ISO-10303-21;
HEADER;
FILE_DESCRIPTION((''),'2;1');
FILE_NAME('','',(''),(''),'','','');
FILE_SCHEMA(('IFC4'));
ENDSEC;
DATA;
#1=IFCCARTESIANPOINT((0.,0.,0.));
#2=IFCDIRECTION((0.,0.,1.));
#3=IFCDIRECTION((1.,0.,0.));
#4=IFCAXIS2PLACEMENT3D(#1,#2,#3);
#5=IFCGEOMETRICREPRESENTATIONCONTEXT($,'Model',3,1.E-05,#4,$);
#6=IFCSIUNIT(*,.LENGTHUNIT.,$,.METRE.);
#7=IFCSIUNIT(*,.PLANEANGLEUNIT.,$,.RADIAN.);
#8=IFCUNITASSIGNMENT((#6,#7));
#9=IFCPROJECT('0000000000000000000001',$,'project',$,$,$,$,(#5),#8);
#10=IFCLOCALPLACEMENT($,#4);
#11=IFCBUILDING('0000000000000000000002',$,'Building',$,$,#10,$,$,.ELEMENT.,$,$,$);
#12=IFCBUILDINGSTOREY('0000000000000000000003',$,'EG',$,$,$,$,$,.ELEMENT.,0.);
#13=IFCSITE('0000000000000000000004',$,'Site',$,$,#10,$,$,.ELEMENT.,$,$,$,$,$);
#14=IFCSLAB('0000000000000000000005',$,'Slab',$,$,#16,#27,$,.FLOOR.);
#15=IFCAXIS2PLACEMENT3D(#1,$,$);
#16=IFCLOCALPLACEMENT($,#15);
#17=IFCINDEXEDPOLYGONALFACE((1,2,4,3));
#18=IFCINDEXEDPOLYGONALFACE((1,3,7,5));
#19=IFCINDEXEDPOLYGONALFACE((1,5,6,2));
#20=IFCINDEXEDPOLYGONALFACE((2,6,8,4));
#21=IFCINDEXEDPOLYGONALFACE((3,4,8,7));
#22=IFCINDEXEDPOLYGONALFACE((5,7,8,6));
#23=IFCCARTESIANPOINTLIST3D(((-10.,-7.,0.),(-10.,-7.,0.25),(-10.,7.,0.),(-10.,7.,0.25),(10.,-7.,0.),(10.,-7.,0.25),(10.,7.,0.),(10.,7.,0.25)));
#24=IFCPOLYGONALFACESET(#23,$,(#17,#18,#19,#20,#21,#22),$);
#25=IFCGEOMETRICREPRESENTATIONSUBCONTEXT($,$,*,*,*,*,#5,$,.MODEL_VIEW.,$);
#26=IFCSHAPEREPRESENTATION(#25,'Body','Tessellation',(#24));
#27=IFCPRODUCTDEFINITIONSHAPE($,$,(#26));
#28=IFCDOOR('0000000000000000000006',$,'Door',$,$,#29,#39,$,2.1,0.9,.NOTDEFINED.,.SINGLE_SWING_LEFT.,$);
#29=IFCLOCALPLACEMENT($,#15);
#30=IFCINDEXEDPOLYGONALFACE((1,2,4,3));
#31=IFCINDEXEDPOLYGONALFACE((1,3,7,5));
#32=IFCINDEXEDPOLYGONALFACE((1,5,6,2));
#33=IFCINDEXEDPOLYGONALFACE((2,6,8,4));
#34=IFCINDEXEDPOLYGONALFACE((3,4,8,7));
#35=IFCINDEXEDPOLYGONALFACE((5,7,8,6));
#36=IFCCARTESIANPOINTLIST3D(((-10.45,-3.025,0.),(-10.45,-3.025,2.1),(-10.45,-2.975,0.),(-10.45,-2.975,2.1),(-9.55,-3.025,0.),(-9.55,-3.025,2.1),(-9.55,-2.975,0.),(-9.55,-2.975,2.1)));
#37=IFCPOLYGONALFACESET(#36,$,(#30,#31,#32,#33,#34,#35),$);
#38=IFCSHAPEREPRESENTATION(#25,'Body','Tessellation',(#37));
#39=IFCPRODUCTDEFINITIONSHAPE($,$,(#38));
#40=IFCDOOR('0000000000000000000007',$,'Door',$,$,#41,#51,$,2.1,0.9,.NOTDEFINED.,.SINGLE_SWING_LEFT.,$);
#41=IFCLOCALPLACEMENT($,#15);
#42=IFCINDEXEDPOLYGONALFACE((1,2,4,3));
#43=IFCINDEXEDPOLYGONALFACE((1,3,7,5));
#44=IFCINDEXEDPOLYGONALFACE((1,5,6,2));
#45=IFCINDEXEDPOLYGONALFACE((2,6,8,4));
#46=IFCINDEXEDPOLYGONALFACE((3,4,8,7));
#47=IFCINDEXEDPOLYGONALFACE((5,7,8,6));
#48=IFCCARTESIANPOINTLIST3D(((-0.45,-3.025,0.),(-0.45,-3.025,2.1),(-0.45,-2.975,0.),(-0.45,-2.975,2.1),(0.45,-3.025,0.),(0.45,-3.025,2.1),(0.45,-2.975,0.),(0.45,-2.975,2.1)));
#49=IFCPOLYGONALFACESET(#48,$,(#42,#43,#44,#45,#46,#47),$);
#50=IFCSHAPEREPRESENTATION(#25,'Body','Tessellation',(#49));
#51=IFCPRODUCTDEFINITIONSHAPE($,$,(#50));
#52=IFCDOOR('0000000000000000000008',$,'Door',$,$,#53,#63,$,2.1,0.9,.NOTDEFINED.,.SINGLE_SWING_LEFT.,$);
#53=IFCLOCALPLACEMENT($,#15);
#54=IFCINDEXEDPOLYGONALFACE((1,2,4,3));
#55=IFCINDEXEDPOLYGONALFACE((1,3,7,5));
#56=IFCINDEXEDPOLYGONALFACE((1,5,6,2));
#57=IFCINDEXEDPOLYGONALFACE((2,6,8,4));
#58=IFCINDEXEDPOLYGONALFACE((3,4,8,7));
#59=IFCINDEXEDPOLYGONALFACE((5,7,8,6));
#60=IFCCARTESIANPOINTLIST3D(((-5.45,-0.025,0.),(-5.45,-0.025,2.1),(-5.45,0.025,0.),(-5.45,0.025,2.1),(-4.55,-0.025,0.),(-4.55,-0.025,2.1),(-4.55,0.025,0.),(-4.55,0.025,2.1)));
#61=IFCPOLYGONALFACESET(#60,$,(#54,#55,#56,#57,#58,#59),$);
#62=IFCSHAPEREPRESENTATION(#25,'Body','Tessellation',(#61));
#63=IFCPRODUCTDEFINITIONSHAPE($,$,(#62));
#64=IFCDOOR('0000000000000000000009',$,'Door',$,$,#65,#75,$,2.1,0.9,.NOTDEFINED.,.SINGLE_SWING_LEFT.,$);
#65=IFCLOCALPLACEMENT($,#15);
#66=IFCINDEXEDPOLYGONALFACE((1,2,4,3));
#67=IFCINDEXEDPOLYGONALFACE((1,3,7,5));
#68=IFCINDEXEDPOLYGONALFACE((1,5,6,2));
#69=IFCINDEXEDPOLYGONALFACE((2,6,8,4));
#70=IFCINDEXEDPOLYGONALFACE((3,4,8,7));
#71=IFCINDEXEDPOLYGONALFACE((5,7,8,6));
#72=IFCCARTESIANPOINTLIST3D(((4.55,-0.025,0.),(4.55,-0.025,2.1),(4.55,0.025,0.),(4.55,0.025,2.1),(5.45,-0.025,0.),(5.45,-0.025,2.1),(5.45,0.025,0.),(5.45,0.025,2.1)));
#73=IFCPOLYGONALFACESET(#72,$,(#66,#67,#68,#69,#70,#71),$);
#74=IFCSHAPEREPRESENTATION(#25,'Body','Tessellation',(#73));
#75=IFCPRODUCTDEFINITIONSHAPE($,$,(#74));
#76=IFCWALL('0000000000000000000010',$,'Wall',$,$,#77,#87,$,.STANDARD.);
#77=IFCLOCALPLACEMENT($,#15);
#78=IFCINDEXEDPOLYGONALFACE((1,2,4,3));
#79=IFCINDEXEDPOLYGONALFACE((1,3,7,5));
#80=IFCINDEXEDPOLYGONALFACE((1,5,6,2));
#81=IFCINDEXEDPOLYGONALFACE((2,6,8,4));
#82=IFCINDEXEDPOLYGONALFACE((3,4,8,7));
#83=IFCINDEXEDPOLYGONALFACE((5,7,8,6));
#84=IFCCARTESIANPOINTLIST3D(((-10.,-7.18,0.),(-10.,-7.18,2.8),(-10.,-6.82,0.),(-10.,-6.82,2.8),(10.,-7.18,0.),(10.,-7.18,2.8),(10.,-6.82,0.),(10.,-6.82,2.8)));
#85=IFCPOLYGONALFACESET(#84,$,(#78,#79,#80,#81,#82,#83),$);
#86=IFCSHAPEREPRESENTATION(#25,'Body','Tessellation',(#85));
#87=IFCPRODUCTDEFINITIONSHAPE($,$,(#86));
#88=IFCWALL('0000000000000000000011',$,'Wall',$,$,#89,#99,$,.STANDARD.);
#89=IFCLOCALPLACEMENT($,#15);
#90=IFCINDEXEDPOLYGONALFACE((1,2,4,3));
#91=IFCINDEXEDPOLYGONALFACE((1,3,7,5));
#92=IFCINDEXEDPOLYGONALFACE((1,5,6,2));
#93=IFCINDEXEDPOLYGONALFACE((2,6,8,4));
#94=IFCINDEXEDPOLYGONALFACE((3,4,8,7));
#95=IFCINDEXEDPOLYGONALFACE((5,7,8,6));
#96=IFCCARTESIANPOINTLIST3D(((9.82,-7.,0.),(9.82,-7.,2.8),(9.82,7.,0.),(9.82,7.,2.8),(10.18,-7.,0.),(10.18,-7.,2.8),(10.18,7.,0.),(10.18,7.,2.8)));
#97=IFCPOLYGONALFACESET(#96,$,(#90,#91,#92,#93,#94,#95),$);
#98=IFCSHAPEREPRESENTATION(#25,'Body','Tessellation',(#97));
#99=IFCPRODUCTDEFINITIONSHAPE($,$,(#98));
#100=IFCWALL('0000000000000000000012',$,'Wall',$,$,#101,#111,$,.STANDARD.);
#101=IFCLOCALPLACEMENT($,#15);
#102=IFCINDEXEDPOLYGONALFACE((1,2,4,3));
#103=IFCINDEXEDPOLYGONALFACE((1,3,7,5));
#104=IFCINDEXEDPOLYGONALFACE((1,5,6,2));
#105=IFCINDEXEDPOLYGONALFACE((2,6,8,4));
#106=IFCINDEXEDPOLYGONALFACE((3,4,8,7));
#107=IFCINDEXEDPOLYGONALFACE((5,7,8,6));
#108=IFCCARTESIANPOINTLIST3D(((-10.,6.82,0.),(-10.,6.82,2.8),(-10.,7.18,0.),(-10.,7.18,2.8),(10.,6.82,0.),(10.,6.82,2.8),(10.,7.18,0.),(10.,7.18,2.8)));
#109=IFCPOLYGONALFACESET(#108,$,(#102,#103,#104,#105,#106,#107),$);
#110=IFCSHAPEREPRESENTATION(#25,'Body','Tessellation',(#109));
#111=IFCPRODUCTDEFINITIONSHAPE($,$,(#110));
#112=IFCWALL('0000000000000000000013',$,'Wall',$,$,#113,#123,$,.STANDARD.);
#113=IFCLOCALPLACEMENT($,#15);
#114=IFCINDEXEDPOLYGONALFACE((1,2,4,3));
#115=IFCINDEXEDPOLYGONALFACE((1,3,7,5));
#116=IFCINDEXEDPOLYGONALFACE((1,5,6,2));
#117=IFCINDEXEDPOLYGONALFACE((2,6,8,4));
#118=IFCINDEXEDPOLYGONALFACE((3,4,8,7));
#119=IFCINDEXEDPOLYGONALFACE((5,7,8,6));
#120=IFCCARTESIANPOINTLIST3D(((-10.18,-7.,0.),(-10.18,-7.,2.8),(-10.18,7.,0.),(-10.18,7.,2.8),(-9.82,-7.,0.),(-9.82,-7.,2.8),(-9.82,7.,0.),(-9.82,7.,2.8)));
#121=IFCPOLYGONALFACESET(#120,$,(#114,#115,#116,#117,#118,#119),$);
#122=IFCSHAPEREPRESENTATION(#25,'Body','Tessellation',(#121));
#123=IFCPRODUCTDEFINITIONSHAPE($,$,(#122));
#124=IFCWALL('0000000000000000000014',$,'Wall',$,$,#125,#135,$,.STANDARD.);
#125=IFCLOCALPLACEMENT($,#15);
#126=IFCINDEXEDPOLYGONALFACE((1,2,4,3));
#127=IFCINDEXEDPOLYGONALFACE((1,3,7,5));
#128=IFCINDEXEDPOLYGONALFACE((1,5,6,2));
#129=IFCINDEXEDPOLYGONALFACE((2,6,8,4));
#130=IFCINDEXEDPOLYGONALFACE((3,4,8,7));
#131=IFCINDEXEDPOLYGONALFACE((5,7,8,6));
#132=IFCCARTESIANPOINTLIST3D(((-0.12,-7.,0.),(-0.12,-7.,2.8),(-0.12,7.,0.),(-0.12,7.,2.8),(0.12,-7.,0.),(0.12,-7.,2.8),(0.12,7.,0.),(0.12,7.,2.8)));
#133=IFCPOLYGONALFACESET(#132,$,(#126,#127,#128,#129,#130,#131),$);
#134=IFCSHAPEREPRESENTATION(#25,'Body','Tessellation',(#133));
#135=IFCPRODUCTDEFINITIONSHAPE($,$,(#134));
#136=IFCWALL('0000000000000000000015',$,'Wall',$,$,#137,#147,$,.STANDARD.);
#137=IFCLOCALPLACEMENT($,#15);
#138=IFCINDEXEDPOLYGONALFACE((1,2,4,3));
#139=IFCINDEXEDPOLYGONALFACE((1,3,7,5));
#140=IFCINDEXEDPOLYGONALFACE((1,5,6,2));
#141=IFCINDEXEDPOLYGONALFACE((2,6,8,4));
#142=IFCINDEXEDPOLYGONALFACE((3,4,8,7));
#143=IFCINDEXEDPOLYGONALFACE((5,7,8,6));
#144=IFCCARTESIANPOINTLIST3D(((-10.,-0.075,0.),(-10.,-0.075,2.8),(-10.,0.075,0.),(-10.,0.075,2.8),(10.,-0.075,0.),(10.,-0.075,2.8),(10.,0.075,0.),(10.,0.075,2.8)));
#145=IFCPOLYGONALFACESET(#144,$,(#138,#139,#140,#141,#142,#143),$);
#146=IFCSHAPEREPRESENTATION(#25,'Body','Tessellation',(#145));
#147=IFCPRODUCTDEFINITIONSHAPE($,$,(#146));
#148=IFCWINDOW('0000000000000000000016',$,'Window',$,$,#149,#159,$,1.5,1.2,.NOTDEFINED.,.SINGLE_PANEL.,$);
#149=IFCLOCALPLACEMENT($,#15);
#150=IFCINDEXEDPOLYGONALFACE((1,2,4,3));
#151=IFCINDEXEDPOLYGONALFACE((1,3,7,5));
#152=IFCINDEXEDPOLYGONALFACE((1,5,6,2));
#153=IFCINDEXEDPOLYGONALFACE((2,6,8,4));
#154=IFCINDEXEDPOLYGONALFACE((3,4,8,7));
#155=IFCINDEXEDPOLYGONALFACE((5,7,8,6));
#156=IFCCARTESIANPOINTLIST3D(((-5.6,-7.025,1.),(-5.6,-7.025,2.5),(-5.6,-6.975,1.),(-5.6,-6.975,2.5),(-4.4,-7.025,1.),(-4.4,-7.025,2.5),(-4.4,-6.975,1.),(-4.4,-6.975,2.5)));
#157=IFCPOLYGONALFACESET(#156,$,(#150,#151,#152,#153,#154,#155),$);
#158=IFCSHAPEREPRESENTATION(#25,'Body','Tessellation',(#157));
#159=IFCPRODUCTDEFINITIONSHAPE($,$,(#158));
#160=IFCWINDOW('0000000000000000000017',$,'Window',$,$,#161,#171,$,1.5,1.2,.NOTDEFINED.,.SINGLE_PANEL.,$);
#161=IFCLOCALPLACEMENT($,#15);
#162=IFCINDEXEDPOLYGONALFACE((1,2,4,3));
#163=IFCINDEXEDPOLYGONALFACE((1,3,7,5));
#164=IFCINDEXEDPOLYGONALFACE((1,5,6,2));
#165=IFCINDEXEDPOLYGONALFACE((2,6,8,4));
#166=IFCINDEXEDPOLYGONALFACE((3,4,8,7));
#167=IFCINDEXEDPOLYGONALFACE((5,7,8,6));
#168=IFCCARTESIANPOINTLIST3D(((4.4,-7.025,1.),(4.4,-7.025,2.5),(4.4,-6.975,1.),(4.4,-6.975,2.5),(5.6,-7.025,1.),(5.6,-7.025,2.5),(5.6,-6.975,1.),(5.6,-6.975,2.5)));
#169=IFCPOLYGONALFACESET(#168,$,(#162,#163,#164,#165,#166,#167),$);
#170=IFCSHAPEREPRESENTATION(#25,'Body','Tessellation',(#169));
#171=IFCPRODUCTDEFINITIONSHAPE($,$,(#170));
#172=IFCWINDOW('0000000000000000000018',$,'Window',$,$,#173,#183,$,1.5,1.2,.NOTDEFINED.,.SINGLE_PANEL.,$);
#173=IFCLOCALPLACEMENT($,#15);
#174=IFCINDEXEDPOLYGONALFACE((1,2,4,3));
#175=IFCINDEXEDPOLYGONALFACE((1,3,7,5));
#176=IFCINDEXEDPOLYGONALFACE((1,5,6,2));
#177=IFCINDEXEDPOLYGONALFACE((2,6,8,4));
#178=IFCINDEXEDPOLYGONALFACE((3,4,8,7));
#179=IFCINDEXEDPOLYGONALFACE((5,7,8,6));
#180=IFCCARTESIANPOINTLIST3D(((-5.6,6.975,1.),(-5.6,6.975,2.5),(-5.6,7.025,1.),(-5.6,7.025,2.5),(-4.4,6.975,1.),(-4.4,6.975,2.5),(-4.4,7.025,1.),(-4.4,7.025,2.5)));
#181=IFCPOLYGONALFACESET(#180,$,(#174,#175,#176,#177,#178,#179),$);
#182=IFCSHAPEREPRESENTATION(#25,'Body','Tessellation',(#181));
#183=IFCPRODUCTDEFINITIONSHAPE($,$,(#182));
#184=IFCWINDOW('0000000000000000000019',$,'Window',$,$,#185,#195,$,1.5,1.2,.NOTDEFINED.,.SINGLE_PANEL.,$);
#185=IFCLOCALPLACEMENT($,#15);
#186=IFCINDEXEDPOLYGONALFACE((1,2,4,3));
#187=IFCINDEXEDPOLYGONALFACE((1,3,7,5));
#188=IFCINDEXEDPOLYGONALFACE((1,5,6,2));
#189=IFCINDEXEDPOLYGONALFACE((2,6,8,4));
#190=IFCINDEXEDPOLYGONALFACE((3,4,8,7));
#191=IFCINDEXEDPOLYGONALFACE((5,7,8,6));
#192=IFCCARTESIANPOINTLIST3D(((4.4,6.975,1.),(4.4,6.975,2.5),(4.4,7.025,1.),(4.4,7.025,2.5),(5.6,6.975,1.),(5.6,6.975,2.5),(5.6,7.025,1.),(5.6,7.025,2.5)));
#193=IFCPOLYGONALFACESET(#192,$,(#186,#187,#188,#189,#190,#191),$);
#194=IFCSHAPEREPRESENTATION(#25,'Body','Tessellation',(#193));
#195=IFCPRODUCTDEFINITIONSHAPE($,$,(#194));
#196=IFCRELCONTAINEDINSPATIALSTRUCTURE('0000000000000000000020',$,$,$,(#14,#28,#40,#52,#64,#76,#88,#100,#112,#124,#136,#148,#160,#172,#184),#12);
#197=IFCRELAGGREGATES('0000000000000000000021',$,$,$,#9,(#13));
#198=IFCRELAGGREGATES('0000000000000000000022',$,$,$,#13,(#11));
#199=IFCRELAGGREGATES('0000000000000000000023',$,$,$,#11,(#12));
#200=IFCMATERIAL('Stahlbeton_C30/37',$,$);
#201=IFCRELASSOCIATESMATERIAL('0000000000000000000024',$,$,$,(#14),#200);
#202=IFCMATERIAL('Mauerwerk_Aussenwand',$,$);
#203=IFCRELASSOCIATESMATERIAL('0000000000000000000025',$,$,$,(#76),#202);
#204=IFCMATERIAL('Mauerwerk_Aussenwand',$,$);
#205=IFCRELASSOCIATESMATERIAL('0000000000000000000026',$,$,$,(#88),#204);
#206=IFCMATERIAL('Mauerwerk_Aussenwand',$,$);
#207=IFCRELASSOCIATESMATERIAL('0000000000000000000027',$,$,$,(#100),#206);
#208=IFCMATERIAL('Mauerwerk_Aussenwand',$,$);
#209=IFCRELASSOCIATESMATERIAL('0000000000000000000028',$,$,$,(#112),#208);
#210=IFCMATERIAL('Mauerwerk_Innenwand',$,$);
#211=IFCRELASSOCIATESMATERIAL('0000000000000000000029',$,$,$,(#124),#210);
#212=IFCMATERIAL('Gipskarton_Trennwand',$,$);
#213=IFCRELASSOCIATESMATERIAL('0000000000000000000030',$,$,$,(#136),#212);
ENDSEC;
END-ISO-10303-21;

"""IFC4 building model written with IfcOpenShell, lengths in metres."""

from ifc_helpers import new_model, si_unit, frame, frame_2d, origin, origin_with_axes, origin_2d, place, context, subcontext, project, spatial, rectangle, extrude, material, element, save


model = new_model("IFC4")

# Units and contexts
model_context = context("Model", 3, precision=1e-05, world=origin_with_axes())
sub_context = subcontext(model_context, None, None, "MODEL_VIEW")
ifc_project = project(units=[si_unit("LENGTHUNIT", "METRE"), si_unit("PLANEANGLEUNIT", "RADIAN")], contexts=[model_context])

# Site, building, storey
placement_1 = place(None, origin_with_axes())
site = spatial("IfcSite", under=ifc_project, at=placement_1, Name="Site", CompositionType="ELEMENT")
building = spatial("IfcBuilding", under=site, at=placement_1, Name="Building", CompositionType="ELEMENT")
storey = spatial("IfcBuildingStorey", under=building, Name="EG", CompositionType="ELEMENT", Elevation=0.0)

# Slab
ifc_material_1 = material(Name="Stahlbeton_C30/37")
placement_2 = place(None, origin_with_axes())
placement_3 = place(placement_2, origin())
slab_placement = place(placement_3, frame((-10.0, -7.0, 0.0)))
element("IfcSlab", 1, at=slab_placement, inside=storey, material=ifc_material_1, Name="Slab", PredefinedType="FLOOR", context=sub_context, shape_type="SweptSolid", body=[
    extrude(rectangle(XDim=20.0, YDim=14.0, at=frame_2d((10.0, 7.0))), origin(), (0.0, 0.0, 1.0), 0.25),
])

# Doors
door_1_placement = place(placement_1, frame((-10.0, -3.0, 0.0)))
element("IfcDoor", 2, at=door_1_placement, inside=storey, Name="Door", OperationType="SINGLE_SWING_LEFT", OverallHeight=2.1, OverallWidth=0.9, PredefinedType="NOTDEFINED", context=sub_context, shape_type="SweptSolid", body=[
    extrude(rectangle(XDim=0.9, YDim=0.05, at=origin_2d()), origin(), (0.0, 0.0, 1.0), 2.1),
])
placement_4 = place(None, origin_with_axes())
door_2_placement = place(placement_4, frame((0.0, -3.0, 0.0)))
element("IfcDoor", 3, at=door_2_placement, inside=storey, Name="Door", OperationType="SINGLE_SWING_LEFT", OverallHeight=2.1, OverallWidth=0.9, PredefinedType="NOTDEFINED", context=sub_context, shape_type="SweptSolid", body=[
    extrude(rectangle(XDim=0.9, YDim=0.05, at=origin_2d()), origin(), (0.0, 0.0, 1.0), 2.1),
])
placement_5 = place(None, origin_with_axes())
door_3_placement = place(placement_5, frame((-5.0, 0.0, 0.0)))
element("IfcDoor", 4, at=door_3_placement, inside=storey, Name="Door", OperationType="SINGLE_SWING_LEFT", OverallHeight=2.1, OverallWidth=0.9, PredefinedType="NOTDEFINED", context=sub_context, shape_type="SweptSolid", body=[
    extrude(rectangle(XDim=0.9, YDim=0.05, at=origin_2d()), origin(), (0.0, 0.0, 1.0), 2.1),
])
placement_6 = place(None, origin_with_axes())
door_4_placement = place(placement_6, frame((5.0, 0.0, 0.0)))
element("IfcDoor", 5, at=door_4_placement, inside=storey, Name="Door", OperationType="SINGLE_SWING_LEFT", OverallHeight=2.1, OverallWidth=0.9, PredefinedType="NOTDEFINED", context=sub_context, shape_type="SweptSolid", body=[
    extrude(rectangle(XDim=0.9, YDim=0.05, at=origin_2d()), origin(), (0.0, 0.0, 1.0), 2.1),
])

# Walls
ifc_material_2 = material(Name="Mauerwerk_Aussenwand")
placement_7 = place(None, origin_with_axes())
placement_8 = place(placement_7, origin())
wall_1_placement = place(placement_8, frame((-10.0, -7.0, 0.0), x_axis=(1.0, 0.0, 0.0)))
element("IfcWall", 6, at=wall_1_placement, inside=storey, material=ifc_material_2, Name="Wall", PredefinedType="STANDARD", context=sub_context, shape_type="SweptSolid", body=[
    extrude(rectangle(XDim=20.0, YDim=0.36, at=frame_2d((10.0, 0.0))), origin(), (0.0, 0.0, 1.0), 2.8),
])
ifc_material_3 = material(Name="Mauerwerk_Aussenwand")
placement_9 = place(None, origin_with_axes())
placement_10 = place(placement_9, origin())
wall_2_placement = place(placement_10, frame((10.0, -7.0, 0.0), x_axis=(0.0, 1.0, 0.0)))
element("IfcWall", 7, at=wall_2_placement, inside=storey, material=ifc_material_3, Name="Wall", PredefinedType="STANDARD", context=sub_context, shape_type="SweptSolid", body=[
    extrude(rectangle(XDim=14.0, YDim=0.36, at=frame_2d((7.0, 0.0))), origin(), (0.0, 0.0, 1.0), 2.8),
])
ifc_material_4 = material(Name="Mauerwerk_Aussenwand")
placement_11 = place(None, origin_with_axes())
placement_12 = place(placement_11, origin())
wall_3_placement = place(placement_12, frame((10.0, 7.0, 0.0), x_axis=(-1.0, 0.0, 0.0)))
element("IfcWall", 8, at=wall_3_placement, inside=storey, material=ifc_material_4, Name="Wall", PredefinedType="STANDARD", context=sub_context, shape_type="SweptSolid", body=[
    extrude(rectangle(XDim=20.0, YDim=0.36, at=frame_2d((10.0, 0.0))), origin(), (0.0, 0.0, 1.0), 2.8),
])
ifc_material_5 = material(Name="Mauerwerk_Aussenwand")
placement_13 = place(None, origin_with_axes())
placement_14 = place(placement_13, origin())
wall_4_placement = place(placement_14, frame((-10.0, 7.0, 0.0), x_axis=(0.0, -1.0, 0.0)))
element("IfcWall", 9, at=wall_4_placement, inside=storey, material=ifc_material_5, Name="Wall", PredefinedType="STANDARD", context=sub_context, shape_type="SweptSolid", body=[
    extrude(rectangle(XDim=14.0, YDim=0.36, at=frame_2d((7.0, 0.0))), origin(), (0.0, 0.0, 1.0), 2.8),
])
ifc_material_6 = material(Name="Mauerwerk_Innenwand")
placement_15 = place(None, origin_with_axes())
placement_16 = place(placement_15, origin())
wall_5_placement = place(placement_16, frame((0.0, -7.0, 0.0), x_axis=(0.0, 1.0, 0.0)))
element("IfcWall", 10, at=wall_5_placement, inside=storey, material=ifc_material_6, Name="Wall", PredefinedType="STANDARD", context=sub_context, shape_type="SweptSolid", body=[
    extrude(rectangle(XDim=14.0, YDim=0.24, at=frame_2d((7.0, 0.0))), origin(), (0.0, 0.0, 1.0), 2.8),
])
ifc_material_7 = material(Name="Gipskarton_Trennwand")
placement_17 = place(None, origin_with_axes())
placement_18 = place(placement_17, origin())
wall_6_placement = place(placement_18, frame((-10.0, 0.0, 0.0), x_axis=(1.0, 0.0, 0.0)))
element("IfcWall", 11, at=wall_6_placement, inside=storey, material=ifc_material_7, Name="Wall", PredefinedType="STANDARD", context=sub_context, shape_type="SweptSolid", body=[
    extrude(rectangle(XDim=20.0, YDim=0.15, at=frame_2d((10.0, 0.0))), origin(), (0.0, 0.0, 1.0), 2.8),
])

# Windows
placement_19 = place(None, origin_with_axes())
window_1_placement = place(placement_19, frame((-5.0, -7.0, 1.0)))
element("IfcWindow", 12, at=window_1_placement, inside=storey, Name="Window", OverallHeight=1.5, OverallWidth=1.2, PartitioningType="SINGLE_PANEL", PredefinedType="NOTDEFINED", context=sub_context, shape_type="SweptSolid", body=[
    extrude(rectangle(XDim=1.2, YDim=0.05, at=origin_2d()), origin(), (0.0, 0.0, 1.0), 1.5),
])
placement_20 = place(None, origin_with_axes())
window_2_placement = place(placement_20, frame((5.0, -7.0, 1.0)))
element("IfcWindow", 13, at=window_2_placement, inside=storey, Name="Window", OverallHeight=1.5, OverallWidth=1.2, PartitioningType="SINGLE_PANEL", PredefinedType="NOTDEFINED", context=sub_context, shape_type="SweptSolid", body=[
    extrude(rectangle(XDim=1.2, YDim=0.05, at=origin_2d()), origin(), (0.0, 0.0, 1.0), 1.5),
])
placement_21 = place(None, origin_with_axes())
window_3_placement = place(placement_21, frame((-5.0, 7.0, 1.0)))
element("IfcWindow", 14, at=window_3_placement, inside=storey, Name="Window", OverallHeight=1.5, OverallWidth=1.2, PartitioningType="SINGLE_PANEL", PredefinedType="NOTDEFINED", context=sub_context, shape_type="SweptSolid", body=[
    extrude(rectangle(XDim=1.2, YDim=0.05, at=origin_2d()), origin(), (0.0, 0.0, 1.0), 1.5),
])
placement_22 = place(None, origin_with_axes())
window_4_placement = place(placement_22, frame((5.0, 7.0, 1.0)))
element("IfcWindow", 15, at=window_4_placement, inside=storey, Name="Window", OverallHeight=1.5, OverallWidth=1.2, PartitioningType="SINGLE_PANEL", PredefinedType="NOTDEFINED", context=sub_context, shape_type="SweptSolid", body=[
    extrude(rectangle(XDim=1.2, YDim=0.05, at=origin_2d()), origin(), (0.0, 0.0, 1.0), 1.5),
])

save(model, "model.ifc")
